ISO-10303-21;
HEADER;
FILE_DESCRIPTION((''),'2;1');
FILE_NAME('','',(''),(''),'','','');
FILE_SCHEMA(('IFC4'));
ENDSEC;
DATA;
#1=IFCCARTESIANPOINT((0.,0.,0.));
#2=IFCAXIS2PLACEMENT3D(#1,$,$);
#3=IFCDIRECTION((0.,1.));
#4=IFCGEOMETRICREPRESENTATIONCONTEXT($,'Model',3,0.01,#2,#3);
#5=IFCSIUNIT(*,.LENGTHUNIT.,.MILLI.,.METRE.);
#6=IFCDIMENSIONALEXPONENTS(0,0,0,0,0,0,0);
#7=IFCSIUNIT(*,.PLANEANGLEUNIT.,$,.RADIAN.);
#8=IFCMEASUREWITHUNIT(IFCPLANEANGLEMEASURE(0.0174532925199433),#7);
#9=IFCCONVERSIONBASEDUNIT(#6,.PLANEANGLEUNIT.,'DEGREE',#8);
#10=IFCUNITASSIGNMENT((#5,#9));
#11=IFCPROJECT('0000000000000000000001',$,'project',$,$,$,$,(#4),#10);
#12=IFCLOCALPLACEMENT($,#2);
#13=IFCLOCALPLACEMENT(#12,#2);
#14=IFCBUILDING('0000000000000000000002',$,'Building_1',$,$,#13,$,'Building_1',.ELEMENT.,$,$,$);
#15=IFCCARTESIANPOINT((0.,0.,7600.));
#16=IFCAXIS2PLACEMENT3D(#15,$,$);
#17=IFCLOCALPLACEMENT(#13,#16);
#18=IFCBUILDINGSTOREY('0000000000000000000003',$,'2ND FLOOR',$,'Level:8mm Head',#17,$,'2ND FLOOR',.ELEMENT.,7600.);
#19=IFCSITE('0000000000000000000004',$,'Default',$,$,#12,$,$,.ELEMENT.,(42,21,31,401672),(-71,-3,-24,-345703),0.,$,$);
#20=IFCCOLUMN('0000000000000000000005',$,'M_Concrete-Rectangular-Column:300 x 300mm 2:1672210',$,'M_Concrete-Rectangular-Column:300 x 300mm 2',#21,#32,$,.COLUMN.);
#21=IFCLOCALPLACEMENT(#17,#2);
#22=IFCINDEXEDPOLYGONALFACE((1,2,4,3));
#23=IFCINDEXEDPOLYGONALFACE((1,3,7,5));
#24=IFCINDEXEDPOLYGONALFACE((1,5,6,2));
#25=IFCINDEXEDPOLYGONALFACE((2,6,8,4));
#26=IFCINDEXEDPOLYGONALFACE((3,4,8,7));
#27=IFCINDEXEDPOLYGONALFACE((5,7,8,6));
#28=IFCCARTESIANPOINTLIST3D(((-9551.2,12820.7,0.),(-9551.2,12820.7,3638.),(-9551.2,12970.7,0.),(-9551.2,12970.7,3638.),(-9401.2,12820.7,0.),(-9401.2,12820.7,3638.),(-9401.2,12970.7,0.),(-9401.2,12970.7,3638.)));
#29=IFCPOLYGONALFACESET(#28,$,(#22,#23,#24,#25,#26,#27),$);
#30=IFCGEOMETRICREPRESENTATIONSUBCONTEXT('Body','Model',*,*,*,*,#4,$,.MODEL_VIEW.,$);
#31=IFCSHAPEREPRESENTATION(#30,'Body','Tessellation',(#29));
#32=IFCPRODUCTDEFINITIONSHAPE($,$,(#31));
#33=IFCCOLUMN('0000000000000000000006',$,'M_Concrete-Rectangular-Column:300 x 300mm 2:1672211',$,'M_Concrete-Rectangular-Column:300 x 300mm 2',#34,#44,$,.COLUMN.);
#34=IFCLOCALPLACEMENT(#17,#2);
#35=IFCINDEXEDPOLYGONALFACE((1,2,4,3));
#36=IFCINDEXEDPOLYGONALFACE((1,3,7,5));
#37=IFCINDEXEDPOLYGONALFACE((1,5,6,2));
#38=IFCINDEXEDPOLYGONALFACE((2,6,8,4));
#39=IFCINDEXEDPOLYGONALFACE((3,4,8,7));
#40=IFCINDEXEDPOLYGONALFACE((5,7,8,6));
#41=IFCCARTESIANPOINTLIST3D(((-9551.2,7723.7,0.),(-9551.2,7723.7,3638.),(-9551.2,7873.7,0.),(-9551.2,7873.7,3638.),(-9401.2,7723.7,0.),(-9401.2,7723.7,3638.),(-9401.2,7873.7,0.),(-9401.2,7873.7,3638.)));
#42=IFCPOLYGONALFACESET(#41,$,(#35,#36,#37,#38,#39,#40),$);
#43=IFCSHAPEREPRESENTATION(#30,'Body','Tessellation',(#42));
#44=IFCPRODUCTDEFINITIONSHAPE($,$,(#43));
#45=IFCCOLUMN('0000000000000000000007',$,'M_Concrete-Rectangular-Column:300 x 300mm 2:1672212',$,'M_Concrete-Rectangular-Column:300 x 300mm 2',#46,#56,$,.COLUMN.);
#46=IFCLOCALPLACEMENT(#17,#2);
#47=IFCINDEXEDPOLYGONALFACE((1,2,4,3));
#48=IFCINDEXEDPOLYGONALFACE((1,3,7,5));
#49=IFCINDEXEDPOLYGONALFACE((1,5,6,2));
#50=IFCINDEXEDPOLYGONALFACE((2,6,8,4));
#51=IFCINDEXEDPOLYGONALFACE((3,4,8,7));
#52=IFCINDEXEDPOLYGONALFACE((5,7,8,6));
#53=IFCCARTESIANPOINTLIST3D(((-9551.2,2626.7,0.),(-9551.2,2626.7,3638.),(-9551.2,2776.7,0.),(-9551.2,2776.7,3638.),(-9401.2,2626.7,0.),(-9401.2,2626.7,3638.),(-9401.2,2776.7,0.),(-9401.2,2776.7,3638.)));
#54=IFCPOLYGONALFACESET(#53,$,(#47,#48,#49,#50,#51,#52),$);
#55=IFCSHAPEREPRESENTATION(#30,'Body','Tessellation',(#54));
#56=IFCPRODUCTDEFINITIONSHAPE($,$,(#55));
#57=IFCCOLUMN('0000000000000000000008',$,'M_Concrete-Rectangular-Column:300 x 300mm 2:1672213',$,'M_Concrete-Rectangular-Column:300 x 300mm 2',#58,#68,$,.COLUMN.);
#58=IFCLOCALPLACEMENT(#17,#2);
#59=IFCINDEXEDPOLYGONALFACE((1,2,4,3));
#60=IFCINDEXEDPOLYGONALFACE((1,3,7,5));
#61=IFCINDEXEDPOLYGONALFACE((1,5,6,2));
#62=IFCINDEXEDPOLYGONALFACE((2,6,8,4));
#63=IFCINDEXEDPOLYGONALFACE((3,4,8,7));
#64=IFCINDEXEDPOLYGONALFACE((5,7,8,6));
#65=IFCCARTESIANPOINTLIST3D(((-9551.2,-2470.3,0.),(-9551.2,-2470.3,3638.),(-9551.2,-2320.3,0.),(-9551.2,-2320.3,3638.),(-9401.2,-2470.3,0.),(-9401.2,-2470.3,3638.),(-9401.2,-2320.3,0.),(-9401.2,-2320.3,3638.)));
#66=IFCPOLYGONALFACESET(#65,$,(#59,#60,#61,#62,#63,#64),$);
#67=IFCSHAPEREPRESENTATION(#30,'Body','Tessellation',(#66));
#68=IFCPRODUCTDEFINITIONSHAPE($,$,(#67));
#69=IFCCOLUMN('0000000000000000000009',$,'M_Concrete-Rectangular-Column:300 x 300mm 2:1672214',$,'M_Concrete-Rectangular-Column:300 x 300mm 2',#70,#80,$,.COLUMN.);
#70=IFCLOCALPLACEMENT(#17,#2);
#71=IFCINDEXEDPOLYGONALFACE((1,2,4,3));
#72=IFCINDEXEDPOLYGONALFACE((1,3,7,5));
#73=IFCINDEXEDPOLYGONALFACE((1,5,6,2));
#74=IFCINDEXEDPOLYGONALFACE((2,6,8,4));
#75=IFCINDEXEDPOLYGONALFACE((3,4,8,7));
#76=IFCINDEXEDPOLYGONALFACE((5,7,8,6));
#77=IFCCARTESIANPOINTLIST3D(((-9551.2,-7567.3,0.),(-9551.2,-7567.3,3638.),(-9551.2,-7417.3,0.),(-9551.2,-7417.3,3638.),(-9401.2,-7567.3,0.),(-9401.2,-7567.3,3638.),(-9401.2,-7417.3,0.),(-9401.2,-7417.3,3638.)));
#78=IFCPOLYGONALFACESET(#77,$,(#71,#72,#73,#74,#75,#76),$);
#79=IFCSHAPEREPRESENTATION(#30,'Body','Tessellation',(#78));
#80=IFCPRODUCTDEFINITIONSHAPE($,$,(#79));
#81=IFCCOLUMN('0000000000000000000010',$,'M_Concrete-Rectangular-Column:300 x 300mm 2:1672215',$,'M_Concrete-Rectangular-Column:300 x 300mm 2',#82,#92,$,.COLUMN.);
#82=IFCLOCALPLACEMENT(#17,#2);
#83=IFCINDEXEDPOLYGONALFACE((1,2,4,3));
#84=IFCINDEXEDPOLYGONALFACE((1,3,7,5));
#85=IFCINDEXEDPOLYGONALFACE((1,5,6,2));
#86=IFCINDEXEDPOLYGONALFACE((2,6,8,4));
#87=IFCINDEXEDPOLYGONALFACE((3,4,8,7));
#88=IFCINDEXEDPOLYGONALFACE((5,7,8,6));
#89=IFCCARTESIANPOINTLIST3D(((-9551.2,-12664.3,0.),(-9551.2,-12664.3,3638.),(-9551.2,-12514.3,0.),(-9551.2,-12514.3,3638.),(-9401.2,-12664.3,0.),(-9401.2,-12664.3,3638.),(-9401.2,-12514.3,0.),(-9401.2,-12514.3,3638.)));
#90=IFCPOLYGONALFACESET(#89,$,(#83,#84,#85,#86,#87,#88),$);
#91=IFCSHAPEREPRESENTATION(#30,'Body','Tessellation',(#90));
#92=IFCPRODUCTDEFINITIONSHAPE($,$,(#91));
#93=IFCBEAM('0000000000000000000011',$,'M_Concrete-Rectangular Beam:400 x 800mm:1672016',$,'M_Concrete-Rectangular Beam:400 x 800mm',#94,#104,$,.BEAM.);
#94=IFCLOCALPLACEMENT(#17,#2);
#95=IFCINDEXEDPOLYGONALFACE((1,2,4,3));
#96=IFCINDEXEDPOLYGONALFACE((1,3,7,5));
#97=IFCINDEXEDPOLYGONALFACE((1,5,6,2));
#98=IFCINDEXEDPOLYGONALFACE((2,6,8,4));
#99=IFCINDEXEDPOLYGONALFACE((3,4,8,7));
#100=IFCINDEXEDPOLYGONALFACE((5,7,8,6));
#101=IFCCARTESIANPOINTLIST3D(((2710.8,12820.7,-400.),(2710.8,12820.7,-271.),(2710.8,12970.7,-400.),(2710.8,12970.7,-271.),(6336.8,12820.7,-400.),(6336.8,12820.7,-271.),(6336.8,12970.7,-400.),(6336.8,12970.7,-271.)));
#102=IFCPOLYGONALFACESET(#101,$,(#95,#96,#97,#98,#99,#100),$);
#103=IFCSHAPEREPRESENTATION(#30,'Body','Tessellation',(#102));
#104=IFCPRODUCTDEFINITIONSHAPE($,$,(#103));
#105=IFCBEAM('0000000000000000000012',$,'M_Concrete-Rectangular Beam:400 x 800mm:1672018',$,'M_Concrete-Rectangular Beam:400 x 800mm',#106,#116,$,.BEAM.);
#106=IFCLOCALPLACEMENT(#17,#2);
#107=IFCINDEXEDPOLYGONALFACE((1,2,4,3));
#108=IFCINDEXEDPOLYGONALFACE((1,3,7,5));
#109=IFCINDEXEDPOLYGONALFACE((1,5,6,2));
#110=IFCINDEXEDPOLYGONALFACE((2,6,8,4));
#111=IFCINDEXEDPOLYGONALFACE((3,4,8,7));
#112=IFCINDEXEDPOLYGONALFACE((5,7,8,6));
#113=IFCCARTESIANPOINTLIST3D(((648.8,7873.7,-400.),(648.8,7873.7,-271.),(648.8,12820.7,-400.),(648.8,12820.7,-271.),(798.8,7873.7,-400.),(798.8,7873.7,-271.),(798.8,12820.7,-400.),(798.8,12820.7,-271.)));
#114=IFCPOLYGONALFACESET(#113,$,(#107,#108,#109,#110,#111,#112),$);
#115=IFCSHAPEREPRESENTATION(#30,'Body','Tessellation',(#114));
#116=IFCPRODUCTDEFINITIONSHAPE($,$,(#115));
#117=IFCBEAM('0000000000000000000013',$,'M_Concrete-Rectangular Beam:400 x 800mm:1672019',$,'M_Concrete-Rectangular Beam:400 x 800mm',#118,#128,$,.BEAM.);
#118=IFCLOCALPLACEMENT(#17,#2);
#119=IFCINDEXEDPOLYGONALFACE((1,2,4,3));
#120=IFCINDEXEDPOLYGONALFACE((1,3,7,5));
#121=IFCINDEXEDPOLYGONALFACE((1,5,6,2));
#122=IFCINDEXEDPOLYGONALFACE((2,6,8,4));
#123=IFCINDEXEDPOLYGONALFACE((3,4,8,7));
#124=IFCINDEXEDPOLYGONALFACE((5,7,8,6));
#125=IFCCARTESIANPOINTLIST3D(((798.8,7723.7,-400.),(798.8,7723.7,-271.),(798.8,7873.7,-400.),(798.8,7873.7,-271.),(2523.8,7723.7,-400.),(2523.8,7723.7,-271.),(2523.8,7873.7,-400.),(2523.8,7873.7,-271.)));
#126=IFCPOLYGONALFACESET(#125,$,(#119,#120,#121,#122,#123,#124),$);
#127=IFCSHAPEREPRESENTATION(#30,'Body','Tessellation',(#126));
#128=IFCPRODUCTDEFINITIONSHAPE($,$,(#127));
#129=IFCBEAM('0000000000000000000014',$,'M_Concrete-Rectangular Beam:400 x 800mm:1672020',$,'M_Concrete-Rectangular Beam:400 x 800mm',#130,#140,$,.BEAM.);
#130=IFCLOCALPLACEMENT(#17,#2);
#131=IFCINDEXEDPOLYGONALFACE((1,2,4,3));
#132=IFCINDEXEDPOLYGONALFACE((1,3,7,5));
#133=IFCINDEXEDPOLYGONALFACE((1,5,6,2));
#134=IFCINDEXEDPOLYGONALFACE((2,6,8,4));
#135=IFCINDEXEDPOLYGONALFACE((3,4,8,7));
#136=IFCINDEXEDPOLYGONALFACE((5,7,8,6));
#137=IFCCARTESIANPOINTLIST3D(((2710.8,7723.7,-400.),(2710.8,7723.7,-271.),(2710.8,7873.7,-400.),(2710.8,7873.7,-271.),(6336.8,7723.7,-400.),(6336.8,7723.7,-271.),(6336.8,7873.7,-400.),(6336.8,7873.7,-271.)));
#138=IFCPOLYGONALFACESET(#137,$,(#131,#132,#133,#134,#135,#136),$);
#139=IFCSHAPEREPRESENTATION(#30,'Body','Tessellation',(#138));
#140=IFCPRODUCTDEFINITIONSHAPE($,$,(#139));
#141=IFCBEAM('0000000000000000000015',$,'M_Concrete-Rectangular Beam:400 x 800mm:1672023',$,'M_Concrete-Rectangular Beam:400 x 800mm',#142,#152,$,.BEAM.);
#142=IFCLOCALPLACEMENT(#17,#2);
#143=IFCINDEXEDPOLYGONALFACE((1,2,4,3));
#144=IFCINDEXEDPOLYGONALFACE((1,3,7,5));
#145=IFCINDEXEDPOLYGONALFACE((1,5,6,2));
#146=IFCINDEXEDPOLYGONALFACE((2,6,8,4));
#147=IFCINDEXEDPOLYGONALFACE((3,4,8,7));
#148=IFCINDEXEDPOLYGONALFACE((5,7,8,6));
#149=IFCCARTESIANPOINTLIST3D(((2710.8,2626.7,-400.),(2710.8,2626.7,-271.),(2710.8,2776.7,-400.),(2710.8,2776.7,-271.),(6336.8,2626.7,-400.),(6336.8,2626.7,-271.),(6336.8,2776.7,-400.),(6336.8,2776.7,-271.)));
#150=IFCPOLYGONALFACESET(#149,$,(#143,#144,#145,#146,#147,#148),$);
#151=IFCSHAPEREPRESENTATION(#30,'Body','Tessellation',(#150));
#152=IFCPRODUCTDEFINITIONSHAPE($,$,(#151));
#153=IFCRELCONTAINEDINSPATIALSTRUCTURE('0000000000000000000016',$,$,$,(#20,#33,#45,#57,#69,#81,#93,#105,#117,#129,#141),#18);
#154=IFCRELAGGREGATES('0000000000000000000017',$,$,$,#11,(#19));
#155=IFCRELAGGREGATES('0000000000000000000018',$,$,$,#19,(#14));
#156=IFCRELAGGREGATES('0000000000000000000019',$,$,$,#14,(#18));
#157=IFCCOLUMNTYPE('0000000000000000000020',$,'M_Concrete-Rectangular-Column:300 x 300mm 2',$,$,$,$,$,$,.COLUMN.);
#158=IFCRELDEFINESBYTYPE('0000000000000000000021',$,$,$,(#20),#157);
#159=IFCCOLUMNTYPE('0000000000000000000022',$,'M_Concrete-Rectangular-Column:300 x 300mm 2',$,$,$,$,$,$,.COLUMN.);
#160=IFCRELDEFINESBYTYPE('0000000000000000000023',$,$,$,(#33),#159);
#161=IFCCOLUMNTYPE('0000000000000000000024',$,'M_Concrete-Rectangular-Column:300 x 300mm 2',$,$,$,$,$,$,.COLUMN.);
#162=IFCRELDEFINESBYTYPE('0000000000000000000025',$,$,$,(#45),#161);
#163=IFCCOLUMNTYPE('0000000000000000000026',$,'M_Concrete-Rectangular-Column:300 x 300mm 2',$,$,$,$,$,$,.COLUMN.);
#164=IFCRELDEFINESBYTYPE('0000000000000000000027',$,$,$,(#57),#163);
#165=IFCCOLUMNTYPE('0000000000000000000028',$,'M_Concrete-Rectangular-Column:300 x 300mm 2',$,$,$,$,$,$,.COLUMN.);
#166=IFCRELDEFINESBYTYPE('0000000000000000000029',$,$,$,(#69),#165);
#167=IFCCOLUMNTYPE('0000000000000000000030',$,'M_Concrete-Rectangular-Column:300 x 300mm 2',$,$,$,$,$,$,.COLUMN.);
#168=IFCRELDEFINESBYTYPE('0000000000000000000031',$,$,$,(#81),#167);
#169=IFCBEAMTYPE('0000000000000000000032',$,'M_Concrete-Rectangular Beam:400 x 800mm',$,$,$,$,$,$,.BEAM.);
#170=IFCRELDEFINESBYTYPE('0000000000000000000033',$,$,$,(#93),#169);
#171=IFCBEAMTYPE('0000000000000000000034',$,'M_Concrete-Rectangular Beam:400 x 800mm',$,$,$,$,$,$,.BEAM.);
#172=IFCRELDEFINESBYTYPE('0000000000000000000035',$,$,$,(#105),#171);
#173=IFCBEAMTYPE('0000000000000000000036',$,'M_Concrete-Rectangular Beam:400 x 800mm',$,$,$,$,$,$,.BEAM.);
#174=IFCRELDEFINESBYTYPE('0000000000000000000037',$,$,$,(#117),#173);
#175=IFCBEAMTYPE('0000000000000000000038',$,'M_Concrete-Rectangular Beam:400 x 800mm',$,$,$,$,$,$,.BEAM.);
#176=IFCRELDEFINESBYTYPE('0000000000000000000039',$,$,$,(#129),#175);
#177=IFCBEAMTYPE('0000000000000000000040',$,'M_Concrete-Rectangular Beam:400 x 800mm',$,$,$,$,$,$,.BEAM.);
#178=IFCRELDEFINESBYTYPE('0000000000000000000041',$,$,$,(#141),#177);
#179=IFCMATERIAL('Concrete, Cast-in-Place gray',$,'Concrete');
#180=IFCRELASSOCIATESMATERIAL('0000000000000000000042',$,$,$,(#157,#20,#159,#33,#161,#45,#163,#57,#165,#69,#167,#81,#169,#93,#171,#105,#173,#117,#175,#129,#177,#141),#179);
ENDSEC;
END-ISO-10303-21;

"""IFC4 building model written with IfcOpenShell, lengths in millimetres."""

from ifc_helpers import new_model, entity, si_unit, converted_unit, direction, frame, origin, place, context, subcontext, project, spatial, indexed_curve, outline, extrude, source, transform, mapped, material, type_object, type_shapes, element, save


model = new_model("IFC4")

# Units and contexts
model_context = context("Model", 3, precision=0.01, world=origin(), true_north=direction((0.0, 1.0)))
body_context = subcontext(model_context, "Body", "Model", "MODEL_VIEW")
ifc_project = project(units=[si_unit("LENGTHUNIT", "METRE", prefix="MILLI"), converted_unit("PLANEANGLEUNIT", "DEGREE", entity("IfcPlaneAngleMeasure", 0.0174532925199433), si_unit("PLANEANGLEUNIT", "RADIAN"), dimensions=[0, 0, 0, 0, 0, 0, 0])], contexts=[model_context])

# Site, building, storey
site_placement = place(None, origin())
site = spatial("IfcSite", under=ifc_project, at=site_placement, Name="Default", CompositionType="ELEMENT", RefLatitude=(42, 21, 31, 401672), RefLongitude=(-71, -3, -24, -345703), RefElevation=0.0)
building_placement = place(site_placement, origin())
building = spatial("IfcBuilding", under=site, at=building_placement, Name="Building_1", LongName="Building_1", CompositionType="ELEMENT")
storey_placement = place(building_placement, frame((0.0, 0.0, 7600.0)))
storey = spatial("IfcBuildingStorey", under=building, at=storey_placement, Name="2ND FLOOR", ObjectType="Level:8mm Head", LongName="2ND FLOOR", CompositionType="ELEMENT", Elevation=7600.0)

# Columns
ifc_material_1 = material(Name="Concrete, Cast-in-Place gray", Category="Concrete")
column_type_1 = type_object("IfcColumnType", Name="M_Concrete-Rectangular-Column:300 x 300mm 2", PredefinedType="COLUMN", material=ifc_material_1)
shared_shape_1 = source(origin(), body_context, "Body", "SweptSolid", [
    extrude(outline(indexed_curve([(-75.0, -75.0), (75.0, -75.0), (75.0, 75.0), (-75.0, 75.0), (-75.0, -75.0)], self_intersect=False)), frame((-9476.2, 12895.7, 7600.0), z_axis=(0.0, 0.0, 1.0), x_axis=(-1.0, 0.0, 0.0)), (0.0, 0.0, 1.0), 3638.0),
])
type_shapes(column_type_1, [shared_shape_1])
column_1_placement = place(storey_placement, frame((0.0, 0.0, -7600.0)))
element("IfcColumn", 1, at=column_1_placement, inside=storey, type_object=column_type_1, material=ifc_material_1, Name="M_Concrete-Rectangular-Column:300 x 300mm 2:1672210", ObjectType="M_Concrete-Rectangular-Column:300 x 300mm 2", PredefinedType="COLUMN", context=body_context, shape_type="MappedRepresentation", body=[
    mapped(shared_shape_1, transform((0.0, 0.0, 0.0), scale=1.0)),
])
column_type_2 = type_object("IfcColumnType", Name="M_Concrete-Rectangular-Column:300 x 300mm 2", PredefinedType="COLUMN", material=ifc_material_1)
shared_shape_2 = source(origin(), body_context, "Body", "SweptSolid", [
    extrude(outline(indexed_curve([(-75.0, -75.0), (75.0, -75.0), (75.0, 75.0), (-75.0, 75.0), (-75.0, -75.0)], self_intersect=False)), frame((-9476.2, 7798.7, 7600.0), z_axis=(0.0, 0.0, 1.0), x_axis=(-1.0, 0.0, 0.0)), (0.0, 0.0, 1.0), 3638.0),
])
type_shapes(column_type_2, [shared_shape_2])
column_2_placement = place(storey_placement, frame((0.0, 0.0, -7600.0)))
element("IfcColumn", 2, at=column_2_placement, inside=storey, type_object=column_type_2, material=ifc_material_1, Name="M_Concrete-Rectangular-Column:300 x 300mm 2:1672211", ObjectType="M_Concrete-Rectangular-Column:300 x 300mm 2", PredefinedType="COLUMN", context=body_context, shape_type="MappedRepresentation", body=[
    mapped(shared_shape_2, transform((0.0, 0.0, 0.0), scale=1.0)),
])
column_type_3 = type_object("IfcColumnType", Name="M_Concrete-Rectangular-Column:300 x 300mm 2", PredefinedType="COLUMN", material=ifc_material_1)
shared_shape_3 = source(origin(), body_context, "Body", "SweptSolid", [
    extrude(outline(indexed_curve([(-75.0, -75.0), (75.0, -75.0), (75.0, 75.0), (-75.0, 75.0), (-75.0, -75.0)], self_intersect=False)), frame((-9476.2, 2701.7, 7600.0), z_axis=(0.0, 0.0, 1.0), x_axis=(-1.0, 0.0, 0.0)), (0.0, 0.0, 1.0), 3638.0),
])
type_shapes(column_type_3, [shared_shape_3])
column_3_placement = place(storey_placement, frame((0.0, 0.0, -7600.0)))
element("IfcColumn", 3, at=column_3_placement, inside=storey, type_object=column_type_3, material=ifc_material_1, Name="M_Concrete-Rectangular-Column:300 x 300mm 2:1672212", ObjectType="M_Concrete-Rectangular-Column:300 x 300mm 2", PredefinedType="COLUMN", context=body_context, shape_type="MappedRepresentation", body=[
    mapped(shared_shape_3, transform((0.0, 0.0, 0.0), scale=1.0)),
])
column_type_4 = type_object("IfcColumnType", Name="M_Concrete-Rectangular-Column:300 x 300mm 2", PredefinedType="COLUMN", material=ifc_material_1)
shared_shape_4 = source(origin(), body_context, "Body", "SweptSolid", [
    extrude(outline(indexed_curve([(-75.0, -75.0), (75.0, -75.0), (75.0, 75.0), (-75.0, 75.0), (-75.0, -75.0)], self_intersect=False)), frame((-9476.2, -2395.3, 7600.0), z_axis=(0.0, 0.0, 1.0), x_axis=(-1.0, 0.0, 0.0)), (0.0, 0.0, 1.0), 3638.0),
])
type_shapes(column_type_4, [shared_shape_4])
column_4_placement = place(storey_placement, frame((0.0, 0.0, -7600.0)))
element("IfcColumn", 4, at=column_4_placement, inside=storey, type_object=column_type_4, material=ifc_material_1, Name="M_Concrete-Rectangular-Column:300 x 300mm 2:1672213", ObjectType="M_Concrete-Rectangular-Column:300 x 300mm 2", PredefinedType="COLUMN", context=body_context, shape_type="MappedRepresentation", body=[
    mapped(shared_shape_4, transform((0.0, 0.0, 0.0), scale=1.0)),
])
column_type_5 = type_object("IfcColumnType", Name="M_Concrete-Rectangular-Column:300 x 300mm 2", PredefinedType="COLUMN", material=ifc_material_1)
shared_shape_5 = source(origin(), body_context, "Body", "SweptSolid", [
    extrude(outline(indexed_curve([(-75.0, -75.0), (75.0, -75.0), (75.0, 75.0), (-75.0, 75.0), (-75.0, -75.0)], self_intersect=False)), frame((-9476.2, -7492.3, 7600.0), z_axis=(0.0, 0.0, 1.0), x_axis=(-1.0, 0.0, 0.0)), (0.0, 0.0, 1.0), 3638.0),
])
type_shapes(column_type_5, [shared_shape_5])
column_5_placement = place(storey_placement, frame((0.0, 0.0, -7600.0)))
element("IfcColumn", 5, at=column_5_placement, inside=storey, type_object=column_type_5, material=ifc_material_1, Name="M_Concrete-Rectangular-Column:300 x 300mm 2:1672214", ObjectType="M_Concrete-Rectangular-Column:300 x 300mm 2", PredefinedType="COLUMN", context=body_context, shape_type="MappedRepresentation", body=[
    mapped(shared_shape_5, transform((0.0, 0.0, 0.0), scale=1.0)),
])
column_type_6 = type_object("IfcColumnType", Name="M_Concrete-Rectangular-Column:300 x 300mm 2", PredefinedType="COLUMN", material=ifc_material_1)
shared_shape_6 = source(origin(), body_context, "Body", "SweptSolid", [
    extrude(outline(indexed_curve([(-75.0, -75.0), (75.0, -75.0), (75.0, 75.0), (-75.0, 75.0), (-75.0, -75.0)], self_intersect=False)), frame((-9476.2, -12589.3, 7600.0), z_axis=(0.0, 0.0, 1.0), x_axis=(-1.0, 0.0, 0.0)), (0.0, 0.0, 1.0), 3638.0),
])
type_shapes(column_type_6, [shared_shape_6])
column_6_placement = place(storey_placement, frame((0.0, 0.0, -7600.0)))
element("IfcColumn", 6, at=column_6_placement, inside=storey, type_object=column_type_6, material=ifc_material_1, Name="M_Concrete-Rectangular-Column:300 x 300mm 2:1672215", ObjectType="M_Concrete-Rectangular-Column:300 x 300mm 2", PredefinedType="COLUMN", context=body_context, shape_type="MappedRepresentation", body=[
    mapped(shared_shape_6, transform((0.0, 0.0, 0.0), scale=1.0)),
])

# Beams
beam_type_1 = type_object("IfcBeamType", Name="M_Concrete-Rectangular Beam:400 x 800mm", PredefinedType="BEAM", material=ifc_material_1)
shared_shape_7 = source(origin(), body_context, "Body", "SweptSolid", [
    extrude(outline(indexed_curve([(-64.5, -75.0), (64.5, -75.0), (64.5, 75.0), (-64.5, 75.0), (-64.5, -75.0)], self_intersect=False)), frame((2710.8, 12895.7, 7264.5), z_axis=(1.0, 0.0, 0.0), x_axis=(0.0, 0.0, -1.0)), (0.0, 0.0, 1.0), 3626.0),
])
type_shapes(beam_type_1, [shared_shape_7])
beam_1_placement = place(storey_placement, frame((0.0, 0.0, -7600.0)))
element("IfcBeam", 7, at=beam_1_placement, inside=storey, type_object=beam_type_1, material=ifc_material_1, Name="M_Concrete-Rectangular Beam:400 x 800mm:1672016", ObjectType="M_Concrete-Rectangular Beam:400 x 800mm", PredefinedType="BEAM", context=body_context, shape_type="MappedRepresentation", body=[
    mapped(shared_shape_7, transform((0.0, 0.0, 0.0), scale=1.0)),
])
beam_type_2 = type_object("IfcBeamType", Name="M_Concrete-Rectangular Beam:400 x 800mm", PredefinedType="BEAM", material=ifc_material_1)
shared_shape_8 = source(origin(), body_context, "Body", "SweptSolid", [
    extrude(outline(indexed_curve([(-75.0, -64.5), (75.0, -64.5), (75.0, 64.5), (-75.0, 64.5), (-75.0, -64.5)], self_intersect=False)), frame((723.8, 12820.7, 7264.5), z_axis=(0.0, -1.0, 0.0), x_axis=(-1.0, 0.0, 0.0)), (0.0, 0.0, 1.0), 4947.0),
])
type_shapes(beam_type_2, [shared_shape_8])
beam_2_placement = place(storey_placement, frame((0.0, 0.0, -7600.0)))
element("IfcBeam", 8, at=beam_2_placement, inside=storey, type_object=beam_type_2, material=ifc_material_1, Name="M_Concrete-Rectangular Beam:400 x 800mm:1672018", ObjectType="M_Concrete-Rectangular Beam:400 x 800mm", PredefinedType="BEAM", context=body_context, shape_type="MappedRepresentation", body=[
    mapped(shared_shape_8, transform((0.0, 0.0, 0.0), scale=1.0)),
])
beam_type_3 = type_object("IfcBeamType", Name="M_Concrete-Rectangular Beam:400 x 800mm", PredefinedType="BEAM", material=ifc_material_1)
shared_shape_9 = source(origin(), body_context, "Body", "SweptSolid", [
    extrude(outline(indexed_curve([(-64.5, -75.0), (64.5, -75.0), (64.5, 75.0), (-64.5, 75.0), (-64.5, -75.0)], self_intersect=False)), frame((798.8, 7798.7, 7264.5), z_axis=(1.0, 0.0, 0.0), x_axis=(0.0, 0.0, -1.0)), (0.0, 0.0, 1.0), 1725.0),
])
type_shapes(beam_type_3, [shared_shape_9])
beam_3_placement = place(storey_placement, frame((0.0, 0.0, -7600.0)))
element("IfcBeam", 9, at=beam_3_placement, inside=storey, type_object=beam_type_3, material=ifc_material_1, Name="M_Concrete-Rectangular Beam:400 x 800mm:1672019", ObjectType="M_Concrete-Rectangular Beam:400 x 800mm", PredefinedType="BEAM", context=body_context, shape_type="MappedRepresentation", body=[
    mapped(shared_shape_9, transform((0.0, 0.0, 0.0), scale=1.0)),
])
beam_type_4 = type_object("IfcBeamType", Name="M_Concrete-Rectangular Beam:400 x 800mm", PredefinedType="BEAM", material=ifc_material_1)
shared_shape_10 = source(origin(), body_context, "Body", "SweptSolid", [
    extrude(outline(indexed_curve([(-64.5, -75.0), (64.5, -75.0), (64.5, 75.0), (-64.5, 75.0), (-64.5, -75.0)], self_intersect=False)), frame((2710.8, 7798.7, 7264.5), z_axis=(1.0, 0.0, 0.0), x_axis=(0.0, 0.0, -1.0)), (0.0, 0.0, 1.0), 3626.0),
])
type_shapes(beam_type_4, [shared_shape_10])
beam_4_placement = place(storey_placement, frame((0.0, 0.0, -7600.0)))
element("IfcBeam", 10, at=beam_4_placement, inside=storey, type_object=beam_type_4, material=ifc_material_1, Name="M_Concrete-Rectangular Beam:400 x 800mm:1672020", ObjectType="M_Concrete-Rectangular Beam:400 x 800mm", PredefinedType="BEAM", context=body_context, shape_type="MappedRepresentation", body=[
    mapped(shared_shape_10, transform((0.0, 0.0, 0.0), scale=1.0)),
])
beam_type_5 = type_object("IfcBeamType", Name="M_Concrete-Rectangular Beam:400 x 800mm", PredefinedType="BEAM", material=ifc_material_1)
shared_shape_11 = source(origin(), body_context, "Body", "SweptSolid", [
    extrude(outline(indexed_curve([(-64.5, -75.0), (64.5, -75.0), (64.5, 75.0), (-64.5, 75.0), (-64.5, -75.0)], self_intersect=False)), frame((6336.8, 2701.7, 7264.5), z_axis=(-1.0, 0.0, 0.0), x_axis=(0.0, 0.0, -1.0)), (0.0, 0.0, 1.0), 3626.0),
])
type_shapes(beam_type_5, [shared_shape_11])
beam_5_placement = place(storey_placement, frame((0.0, 0.0, -7600.0)))
element("IfcBeam", 11, at=beam_5_placement, inside=storey, type_object=beam_type_5, material=ifc_material_1, Name="M_Concrete-Rectangular Beam:400 x 800mm:1672023", ObjectType="M_Concrete-Rectangular Beam:400 x 800mm", PredefinedType="BEAM", context=body_context, shape_type="MappedRepresentation", body=[
    mapped(shared_shape_11, transform((0.0, 0.0, 0.0), scale=1.0)),
])

save(model, "model.ifc")
